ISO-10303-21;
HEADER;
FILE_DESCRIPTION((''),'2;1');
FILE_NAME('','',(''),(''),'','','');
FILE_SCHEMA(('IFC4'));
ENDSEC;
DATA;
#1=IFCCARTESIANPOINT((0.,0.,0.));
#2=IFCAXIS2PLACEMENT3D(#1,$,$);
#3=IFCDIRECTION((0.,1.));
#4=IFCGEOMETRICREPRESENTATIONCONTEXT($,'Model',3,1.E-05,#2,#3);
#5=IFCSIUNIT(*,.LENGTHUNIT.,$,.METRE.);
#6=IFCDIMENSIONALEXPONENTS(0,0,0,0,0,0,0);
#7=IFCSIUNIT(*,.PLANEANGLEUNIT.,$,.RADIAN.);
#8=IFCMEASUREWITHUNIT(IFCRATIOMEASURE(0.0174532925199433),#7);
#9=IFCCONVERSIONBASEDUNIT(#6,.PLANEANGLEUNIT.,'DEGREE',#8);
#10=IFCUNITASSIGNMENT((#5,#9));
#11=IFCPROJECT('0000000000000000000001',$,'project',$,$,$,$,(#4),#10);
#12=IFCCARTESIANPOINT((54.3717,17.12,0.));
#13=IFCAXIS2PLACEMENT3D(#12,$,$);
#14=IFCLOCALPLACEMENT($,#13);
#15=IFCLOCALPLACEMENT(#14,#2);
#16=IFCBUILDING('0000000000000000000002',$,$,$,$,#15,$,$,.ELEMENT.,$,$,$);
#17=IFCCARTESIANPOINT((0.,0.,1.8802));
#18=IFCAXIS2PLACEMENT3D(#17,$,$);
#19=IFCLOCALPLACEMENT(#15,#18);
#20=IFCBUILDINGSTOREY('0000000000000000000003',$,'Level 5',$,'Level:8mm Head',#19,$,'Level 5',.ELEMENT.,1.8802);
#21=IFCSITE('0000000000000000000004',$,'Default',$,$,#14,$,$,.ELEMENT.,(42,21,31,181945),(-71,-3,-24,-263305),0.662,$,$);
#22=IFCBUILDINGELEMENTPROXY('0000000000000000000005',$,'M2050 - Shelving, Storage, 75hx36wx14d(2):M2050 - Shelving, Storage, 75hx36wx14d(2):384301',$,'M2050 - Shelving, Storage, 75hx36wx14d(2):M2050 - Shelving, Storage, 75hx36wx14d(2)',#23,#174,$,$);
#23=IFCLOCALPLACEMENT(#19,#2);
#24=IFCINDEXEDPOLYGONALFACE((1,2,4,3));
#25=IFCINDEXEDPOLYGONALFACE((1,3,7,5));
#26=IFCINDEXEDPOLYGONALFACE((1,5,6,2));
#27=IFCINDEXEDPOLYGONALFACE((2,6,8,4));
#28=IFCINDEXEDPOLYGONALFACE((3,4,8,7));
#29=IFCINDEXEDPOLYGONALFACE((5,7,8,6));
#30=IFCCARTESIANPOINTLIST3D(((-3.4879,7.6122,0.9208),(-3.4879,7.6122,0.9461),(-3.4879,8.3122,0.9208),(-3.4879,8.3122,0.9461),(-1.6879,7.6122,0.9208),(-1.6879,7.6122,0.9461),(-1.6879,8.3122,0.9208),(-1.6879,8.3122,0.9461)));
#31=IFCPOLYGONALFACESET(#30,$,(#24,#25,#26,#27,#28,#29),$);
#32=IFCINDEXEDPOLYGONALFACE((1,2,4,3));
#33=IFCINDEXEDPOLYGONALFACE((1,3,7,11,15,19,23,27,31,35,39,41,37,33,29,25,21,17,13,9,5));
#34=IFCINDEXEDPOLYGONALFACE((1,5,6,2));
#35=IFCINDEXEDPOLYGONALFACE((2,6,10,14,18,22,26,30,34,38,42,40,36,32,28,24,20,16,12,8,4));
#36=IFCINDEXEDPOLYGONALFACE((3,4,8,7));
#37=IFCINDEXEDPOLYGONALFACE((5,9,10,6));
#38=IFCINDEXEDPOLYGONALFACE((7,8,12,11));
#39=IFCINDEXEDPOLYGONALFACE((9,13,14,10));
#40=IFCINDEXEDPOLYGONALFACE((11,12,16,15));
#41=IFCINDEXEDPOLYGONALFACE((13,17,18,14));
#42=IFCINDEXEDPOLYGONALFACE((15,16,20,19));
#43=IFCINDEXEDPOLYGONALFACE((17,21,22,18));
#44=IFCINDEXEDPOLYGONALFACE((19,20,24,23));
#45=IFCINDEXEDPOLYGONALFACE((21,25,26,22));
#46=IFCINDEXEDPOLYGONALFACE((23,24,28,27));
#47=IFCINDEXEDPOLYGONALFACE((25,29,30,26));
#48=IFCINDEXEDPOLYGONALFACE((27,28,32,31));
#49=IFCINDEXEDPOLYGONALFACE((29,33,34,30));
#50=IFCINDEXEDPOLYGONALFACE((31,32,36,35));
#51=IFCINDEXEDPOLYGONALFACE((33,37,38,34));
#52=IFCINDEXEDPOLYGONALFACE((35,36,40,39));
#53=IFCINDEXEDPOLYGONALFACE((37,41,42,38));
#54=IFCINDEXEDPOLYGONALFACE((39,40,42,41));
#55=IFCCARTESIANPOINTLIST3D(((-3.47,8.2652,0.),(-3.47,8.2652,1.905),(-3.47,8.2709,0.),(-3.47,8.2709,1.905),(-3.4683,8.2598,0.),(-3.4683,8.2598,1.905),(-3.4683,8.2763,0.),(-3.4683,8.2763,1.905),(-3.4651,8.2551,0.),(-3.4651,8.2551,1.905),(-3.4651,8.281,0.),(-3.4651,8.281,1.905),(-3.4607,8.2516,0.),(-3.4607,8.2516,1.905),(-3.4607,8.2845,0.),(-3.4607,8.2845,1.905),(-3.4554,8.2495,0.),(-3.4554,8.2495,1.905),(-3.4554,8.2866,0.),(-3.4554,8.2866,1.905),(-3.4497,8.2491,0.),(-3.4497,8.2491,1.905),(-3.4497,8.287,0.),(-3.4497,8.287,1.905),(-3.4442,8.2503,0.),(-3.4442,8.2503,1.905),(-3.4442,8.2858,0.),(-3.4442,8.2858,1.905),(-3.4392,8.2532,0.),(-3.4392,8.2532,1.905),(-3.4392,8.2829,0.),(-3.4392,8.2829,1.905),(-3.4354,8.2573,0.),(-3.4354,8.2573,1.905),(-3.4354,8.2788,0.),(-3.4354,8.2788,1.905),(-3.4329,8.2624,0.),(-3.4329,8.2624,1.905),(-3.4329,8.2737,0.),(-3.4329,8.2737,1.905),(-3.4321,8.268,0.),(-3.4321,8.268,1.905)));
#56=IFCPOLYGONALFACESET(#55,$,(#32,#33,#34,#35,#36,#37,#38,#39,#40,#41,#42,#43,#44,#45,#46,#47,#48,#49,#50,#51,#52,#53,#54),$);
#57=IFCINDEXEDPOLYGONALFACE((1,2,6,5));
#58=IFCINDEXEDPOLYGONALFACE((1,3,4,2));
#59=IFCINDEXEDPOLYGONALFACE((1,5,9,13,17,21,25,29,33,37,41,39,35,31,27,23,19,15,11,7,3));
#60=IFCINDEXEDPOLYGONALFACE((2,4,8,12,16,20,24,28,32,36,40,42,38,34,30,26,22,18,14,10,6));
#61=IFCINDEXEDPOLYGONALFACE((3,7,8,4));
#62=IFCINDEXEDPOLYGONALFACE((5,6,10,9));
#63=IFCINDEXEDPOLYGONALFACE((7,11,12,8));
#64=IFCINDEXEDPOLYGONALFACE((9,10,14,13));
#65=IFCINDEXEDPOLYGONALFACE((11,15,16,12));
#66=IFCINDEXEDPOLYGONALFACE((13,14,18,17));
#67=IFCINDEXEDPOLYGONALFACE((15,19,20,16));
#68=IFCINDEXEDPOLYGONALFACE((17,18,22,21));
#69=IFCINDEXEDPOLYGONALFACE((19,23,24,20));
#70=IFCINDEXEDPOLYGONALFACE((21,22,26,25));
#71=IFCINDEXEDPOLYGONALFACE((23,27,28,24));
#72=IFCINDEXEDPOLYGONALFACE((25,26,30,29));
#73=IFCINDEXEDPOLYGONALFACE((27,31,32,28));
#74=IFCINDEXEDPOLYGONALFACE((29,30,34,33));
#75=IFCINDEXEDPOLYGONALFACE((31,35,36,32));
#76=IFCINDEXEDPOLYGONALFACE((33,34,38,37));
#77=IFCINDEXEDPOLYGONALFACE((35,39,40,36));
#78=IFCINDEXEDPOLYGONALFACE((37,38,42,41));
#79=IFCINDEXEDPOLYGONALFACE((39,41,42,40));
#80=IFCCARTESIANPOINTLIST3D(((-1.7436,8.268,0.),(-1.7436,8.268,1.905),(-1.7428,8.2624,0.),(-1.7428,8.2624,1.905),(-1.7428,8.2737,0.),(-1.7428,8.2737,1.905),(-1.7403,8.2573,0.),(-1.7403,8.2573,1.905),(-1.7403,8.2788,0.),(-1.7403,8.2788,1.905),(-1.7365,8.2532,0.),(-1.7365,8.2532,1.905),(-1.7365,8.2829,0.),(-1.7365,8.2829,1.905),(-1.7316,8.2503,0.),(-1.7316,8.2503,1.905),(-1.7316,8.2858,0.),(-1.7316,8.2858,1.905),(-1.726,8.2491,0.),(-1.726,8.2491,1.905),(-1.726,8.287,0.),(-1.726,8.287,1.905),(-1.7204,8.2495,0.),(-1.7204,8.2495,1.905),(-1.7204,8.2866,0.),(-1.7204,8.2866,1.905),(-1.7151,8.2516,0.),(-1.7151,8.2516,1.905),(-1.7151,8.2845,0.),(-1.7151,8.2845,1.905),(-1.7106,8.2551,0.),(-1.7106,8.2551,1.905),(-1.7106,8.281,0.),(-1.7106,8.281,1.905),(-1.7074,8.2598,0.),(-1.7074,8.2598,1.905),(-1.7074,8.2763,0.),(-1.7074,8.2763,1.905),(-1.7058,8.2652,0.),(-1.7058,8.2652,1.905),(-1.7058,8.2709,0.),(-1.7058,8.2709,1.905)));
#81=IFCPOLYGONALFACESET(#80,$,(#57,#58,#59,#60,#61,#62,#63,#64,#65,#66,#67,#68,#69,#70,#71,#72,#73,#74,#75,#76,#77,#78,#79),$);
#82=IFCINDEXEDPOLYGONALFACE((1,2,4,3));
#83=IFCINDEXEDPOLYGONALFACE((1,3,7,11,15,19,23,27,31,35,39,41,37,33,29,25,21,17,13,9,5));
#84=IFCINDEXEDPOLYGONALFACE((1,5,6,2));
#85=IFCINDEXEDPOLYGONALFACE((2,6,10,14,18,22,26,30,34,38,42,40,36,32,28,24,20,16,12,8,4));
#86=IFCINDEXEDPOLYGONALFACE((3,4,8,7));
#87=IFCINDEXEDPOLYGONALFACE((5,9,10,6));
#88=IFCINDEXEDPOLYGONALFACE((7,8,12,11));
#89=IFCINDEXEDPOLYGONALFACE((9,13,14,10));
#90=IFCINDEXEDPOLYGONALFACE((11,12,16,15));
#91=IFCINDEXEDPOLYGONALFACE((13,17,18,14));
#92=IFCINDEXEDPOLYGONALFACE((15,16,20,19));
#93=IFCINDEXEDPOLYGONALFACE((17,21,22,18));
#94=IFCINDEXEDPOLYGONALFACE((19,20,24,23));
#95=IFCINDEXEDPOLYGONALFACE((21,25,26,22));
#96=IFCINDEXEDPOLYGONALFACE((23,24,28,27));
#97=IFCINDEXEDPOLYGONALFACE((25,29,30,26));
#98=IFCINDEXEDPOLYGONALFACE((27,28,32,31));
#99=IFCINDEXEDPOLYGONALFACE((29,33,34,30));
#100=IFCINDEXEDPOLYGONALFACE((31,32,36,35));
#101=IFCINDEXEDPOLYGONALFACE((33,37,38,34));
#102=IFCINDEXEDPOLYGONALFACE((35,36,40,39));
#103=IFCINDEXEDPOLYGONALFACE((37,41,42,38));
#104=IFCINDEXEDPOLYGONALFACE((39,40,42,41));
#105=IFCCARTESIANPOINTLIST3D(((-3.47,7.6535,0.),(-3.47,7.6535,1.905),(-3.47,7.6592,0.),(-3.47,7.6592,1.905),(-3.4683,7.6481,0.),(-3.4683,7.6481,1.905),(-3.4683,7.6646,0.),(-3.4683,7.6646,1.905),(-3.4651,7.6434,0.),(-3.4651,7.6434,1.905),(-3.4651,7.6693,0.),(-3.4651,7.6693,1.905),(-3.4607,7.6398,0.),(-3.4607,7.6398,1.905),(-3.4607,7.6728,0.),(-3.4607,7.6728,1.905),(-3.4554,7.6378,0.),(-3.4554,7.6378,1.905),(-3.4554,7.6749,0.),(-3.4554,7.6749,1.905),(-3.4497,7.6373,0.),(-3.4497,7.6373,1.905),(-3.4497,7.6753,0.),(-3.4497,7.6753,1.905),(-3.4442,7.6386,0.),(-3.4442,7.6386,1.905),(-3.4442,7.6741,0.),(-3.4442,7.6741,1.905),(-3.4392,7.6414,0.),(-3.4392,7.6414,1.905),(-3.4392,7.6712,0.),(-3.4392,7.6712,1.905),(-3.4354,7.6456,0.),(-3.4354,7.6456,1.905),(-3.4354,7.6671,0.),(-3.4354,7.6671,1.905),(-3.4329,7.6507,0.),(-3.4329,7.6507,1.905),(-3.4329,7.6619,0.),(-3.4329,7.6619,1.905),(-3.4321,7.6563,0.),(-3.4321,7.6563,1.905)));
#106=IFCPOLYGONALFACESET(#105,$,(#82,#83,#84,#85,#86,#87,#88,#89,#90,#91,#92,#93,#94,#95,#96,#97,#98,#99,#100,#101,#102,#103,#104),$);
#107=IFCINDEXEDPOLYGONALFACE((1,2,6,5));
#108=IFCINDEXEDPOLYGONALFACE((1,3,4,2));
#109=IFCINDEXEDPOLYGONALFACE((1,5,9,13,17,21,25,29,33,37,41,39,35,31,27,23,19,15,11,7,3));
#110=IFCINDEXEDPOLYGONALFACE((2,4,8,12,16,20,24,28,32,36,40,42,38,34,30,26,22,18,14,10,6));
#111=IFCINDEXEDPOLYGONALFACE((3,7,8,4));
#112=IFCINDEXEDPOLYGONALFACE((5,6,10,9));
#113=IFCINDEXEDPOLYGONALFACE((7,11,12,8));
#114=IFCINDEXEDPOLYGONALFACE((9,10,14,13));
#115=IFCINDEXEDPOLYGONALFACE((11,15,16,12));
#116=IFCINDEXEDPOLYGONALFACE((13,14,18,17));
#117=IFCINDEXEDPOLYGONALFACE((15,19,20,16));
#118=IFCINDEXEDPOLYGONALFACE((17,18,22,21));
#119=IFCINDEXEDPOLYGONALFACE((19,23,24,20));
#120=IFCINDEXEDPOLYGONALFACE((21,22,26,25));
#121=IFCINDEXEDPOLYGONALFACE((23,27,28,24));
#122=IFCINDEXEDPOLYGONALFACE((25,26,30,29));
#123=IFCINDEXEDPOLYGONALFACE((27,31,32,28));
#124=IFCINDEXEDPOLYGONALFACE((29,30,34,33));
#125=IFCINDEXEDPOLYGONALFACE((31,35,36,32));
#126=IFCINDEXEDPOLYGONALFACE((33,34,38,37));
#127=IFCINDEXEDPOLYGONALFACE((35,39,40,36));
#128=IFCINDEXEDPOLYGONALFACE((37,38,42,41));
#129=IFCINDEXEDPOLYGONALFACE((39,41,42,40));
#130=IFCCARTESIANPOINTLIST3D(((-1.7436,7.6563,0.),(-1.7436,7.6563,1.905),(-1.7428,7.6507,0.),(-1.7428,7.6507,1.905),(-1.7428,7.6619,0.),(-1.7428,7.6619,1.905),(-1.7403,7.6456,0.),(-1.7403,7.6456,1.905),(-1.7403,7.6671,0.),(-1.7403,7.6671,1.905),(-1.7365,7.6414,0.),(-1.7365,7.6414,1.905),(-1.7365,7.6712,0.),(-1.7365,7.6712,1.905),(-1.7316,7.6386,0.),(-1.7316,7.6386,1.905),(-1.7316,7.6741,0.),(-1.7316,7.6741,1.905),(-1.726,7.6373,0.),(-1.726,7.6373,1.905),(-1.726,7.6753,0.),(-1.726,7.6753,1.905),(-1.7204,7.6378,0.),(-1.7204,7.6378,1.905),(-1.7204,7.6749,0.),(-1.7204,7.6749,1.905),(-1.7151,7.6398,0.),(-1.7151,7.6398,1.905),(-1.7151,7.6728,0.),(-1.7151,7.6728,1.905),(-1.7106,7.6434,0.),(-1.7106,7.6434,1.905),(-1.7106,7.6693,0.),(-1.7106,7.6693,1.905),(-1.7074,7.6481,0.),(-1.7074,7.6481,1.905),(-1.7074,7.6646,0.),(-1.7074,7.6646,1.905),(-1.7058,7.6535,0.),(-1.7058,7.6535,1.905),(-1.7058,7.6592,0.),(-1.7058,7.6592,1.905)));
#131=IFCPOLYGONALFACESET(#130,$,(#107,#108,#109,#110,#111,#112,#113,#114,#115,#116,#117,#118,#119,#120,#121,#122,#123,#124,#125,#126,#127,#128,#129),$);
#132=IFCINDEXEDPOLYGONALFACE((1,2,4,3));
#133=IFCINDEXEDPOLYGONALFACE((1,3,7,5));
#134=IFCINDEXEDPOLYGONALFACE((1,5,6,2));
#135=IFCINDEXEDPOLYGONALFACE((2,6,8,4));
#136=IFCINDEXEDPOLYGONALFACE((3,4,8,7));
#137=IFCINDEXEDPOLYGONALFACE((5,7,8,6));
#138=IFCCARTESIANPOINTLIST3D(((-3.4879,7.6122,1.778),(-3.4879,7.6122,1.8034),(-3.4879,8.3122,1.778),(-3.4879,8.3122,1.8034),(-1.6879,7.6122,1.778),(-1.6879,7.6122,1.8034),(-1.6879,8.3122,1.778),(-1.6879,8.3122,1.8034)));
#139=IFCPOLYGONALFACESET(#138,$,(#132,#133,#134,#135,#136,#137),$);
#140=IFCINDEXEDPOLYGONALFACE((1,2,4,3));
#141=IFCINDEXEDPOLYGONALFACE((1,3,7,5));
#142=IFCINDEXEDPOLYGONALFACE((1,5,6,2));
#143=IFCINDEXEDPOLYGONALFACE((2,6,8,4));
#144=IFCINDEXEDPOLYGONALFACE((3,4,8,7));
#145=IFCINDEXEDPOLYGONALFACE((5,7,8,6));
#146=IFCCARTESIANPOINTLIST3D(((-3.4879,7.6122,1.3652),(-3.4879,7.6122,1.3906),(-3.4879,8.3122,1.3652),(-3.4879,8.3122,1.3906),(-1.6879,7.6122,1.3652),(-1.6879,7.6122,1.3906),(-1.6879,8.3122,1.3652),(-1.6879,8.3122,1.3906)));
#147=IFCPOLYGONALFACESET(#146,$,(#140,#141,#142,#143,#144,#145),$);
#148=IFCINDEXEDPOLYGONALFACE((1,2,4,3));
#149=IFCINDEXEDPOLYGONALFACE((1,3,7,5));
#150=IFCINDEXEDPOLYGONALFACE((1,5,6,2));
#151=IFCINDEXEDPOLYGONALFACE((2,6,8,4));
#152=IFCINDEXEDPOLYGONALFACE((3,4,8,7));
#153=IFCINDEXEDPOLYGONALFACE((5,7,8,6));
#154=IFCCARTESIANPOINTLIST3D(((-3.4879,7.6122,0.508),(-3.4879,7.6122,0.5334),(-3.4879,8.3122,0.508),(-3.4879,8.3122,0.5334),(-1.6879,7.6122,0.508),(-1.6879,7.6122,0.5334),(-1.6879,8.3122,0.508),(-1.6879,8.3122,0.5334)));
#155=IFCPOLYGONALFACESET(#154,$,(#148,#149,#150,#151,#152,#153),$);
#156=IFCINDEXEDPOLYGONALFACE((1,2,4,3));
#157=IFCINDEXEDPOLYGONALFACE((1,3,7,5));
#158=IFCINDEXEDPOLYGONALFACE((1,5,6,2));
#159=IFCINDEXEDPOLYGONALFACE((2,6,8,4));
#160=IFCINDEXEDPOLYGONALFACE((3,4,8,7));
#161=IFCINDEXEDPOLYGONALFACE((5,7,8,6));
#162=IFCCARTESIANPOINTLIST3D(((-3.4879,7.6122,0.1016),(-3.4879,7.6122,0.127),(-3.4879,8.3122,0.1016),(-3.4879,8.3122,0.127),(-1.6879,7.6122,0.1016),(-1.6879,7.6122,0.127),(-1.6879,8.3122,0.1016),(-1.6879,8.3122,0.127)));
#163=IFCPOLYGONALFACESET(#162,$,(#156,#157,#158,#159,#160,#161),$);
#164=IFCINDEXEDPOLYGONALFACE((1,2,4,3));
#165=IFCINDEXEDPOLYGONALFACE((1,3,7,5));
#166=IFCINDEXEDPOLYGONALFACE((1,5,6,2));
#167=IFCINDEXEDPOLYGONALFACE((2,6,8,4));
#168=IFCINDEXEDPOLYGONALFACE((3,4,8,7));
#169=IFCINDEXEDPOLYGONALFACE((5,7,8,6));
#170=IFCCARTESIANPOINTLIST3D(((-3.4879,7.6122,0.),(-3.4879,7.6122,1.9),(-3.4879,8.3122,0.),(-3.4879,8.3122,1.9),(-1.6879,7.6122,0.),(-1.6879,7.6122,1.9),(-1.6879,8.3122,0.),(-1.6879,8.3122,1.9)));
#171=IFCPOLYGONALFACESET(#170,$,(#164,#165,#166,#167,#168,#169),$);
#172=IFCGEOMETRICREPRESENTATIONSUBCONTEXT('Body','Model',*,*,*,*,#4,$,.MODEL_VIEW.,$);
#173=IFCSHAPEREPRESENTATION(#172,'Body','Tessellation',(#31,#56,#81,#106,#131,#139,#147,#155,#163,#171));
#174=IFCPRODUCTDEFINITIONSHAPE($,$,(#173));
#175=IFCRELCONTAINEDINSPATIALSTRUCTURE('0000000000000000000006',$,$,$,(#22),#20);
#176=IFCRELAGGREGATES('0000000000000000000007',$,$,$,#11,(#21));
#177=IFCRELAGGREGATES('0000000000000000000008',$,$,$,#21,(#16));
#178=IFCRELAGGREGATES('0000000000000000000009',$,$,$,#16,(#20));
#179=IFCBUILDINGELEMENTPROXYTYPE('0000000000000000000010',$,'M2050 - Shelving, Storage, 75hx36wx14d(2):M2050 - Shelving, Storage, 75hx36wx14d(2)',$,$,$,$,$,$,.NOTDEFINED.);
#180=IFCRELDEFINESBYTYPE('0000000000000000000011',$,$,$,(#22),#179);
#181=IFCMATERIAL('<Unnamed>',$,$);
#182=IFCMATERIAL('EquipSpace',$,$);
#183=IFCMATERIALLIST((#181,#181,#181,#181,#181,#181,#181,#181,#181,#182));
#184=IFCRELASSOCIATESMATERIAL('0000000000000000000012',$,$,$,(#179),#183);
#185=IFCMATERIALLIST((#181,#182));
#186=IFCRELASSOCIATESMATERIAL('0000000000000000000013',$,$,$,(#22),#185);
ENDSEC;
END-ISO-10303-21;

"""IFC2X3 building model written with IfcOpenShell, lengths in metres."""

from ifc_helpers import new_model, entity, si_unit, converted_unit, direction, frame, frame_2d, origin, origin_2d_with_axis, place, context, subcontext, project, spatial, rectangle, circle, extrude, source, transform, mapped, material, material_list, type_object, type_shapes, element, save


model = new_model("IFC2X3")

# Units and contexts
model_context = context("Model", 3, precision=1e-05, world=origin(), true_north=direction((0.0, 1.0)))
body_context = subcontext(model_context, "Body", "Model", "MODEL_VIEW")
ifc_project = project(units=[si_unit("LENGTHUNIT", "METRE"), converted_unit("PLANEANGLEUNIT", "DEGREE", entity("IfcRatioMeasure", 0.0174532925199433), si_unit("PLANEANGLEUNIT", "RADIAN"), dimensions=[0, 0, 0, 0, 0, 0, 0])], contexts=[model_context])

# Site, building, storey
site_placement = place(None, frame((54.3717, 17.12, 0.0)))
site = spatial("IfcSite", under=ifc_project, at=site_placement, Name="Default", CompositionType="ELEMENT", RefLatitude=(42, 21, 31, 181945), RefLongitude=(-71, -3, -24, -263305), RefElevation=0.662)
building_placement = place(site_placement, origin())
building = spatial("IfcBuilding", under=site, at=building_placement, CompositionType="ELEMENT")
storey_placement = place(building_placement, frame((0.0, 0.0, 1.8802)))
storey = spatial("IfcBuildingStorey", under=building, at=storey_placement, Name="Level 5", ObjectType="Level:8mm Head", LongName="Level 5", CompositionType="ELEMENT", Elevation=1.8802)

# Building element proxy
ifc_material_1 = material(Name="<Unnamed>")
ifc_material_2 = material(Name="EquipSpace")
ifc_material_list_1 = material_list([ifc_material_1, ifc_material_1, ifc_material_1, ifc_material_1, ifc_material_1, ifc_material_1, ifc_material_1, ifc_material_1, ifc_material_1, ifc_material_2])
building_element_proxy_type = type_object("IfcBuildingElementProxyType", Name="M2050 - Shelving, Storage, 75hx36wx14d(2):M2050 - Shelving, Storage, 75hx36wx14d(2)", PredefinedType="NOTDEFINED", material=ifc_material_list_1)
shared_shape = source(origin(), body_context, "Body", "SweptSolid", [
    extrude(rectangle(XDim=1.8, YDim=0.7, at=origin_2d_with_axis()), frame((0.0, 0.0, 0.9207), z_axis=(0.0, 0.0, 1.0), x_axis=(-1.0, 0.0, 0.0)), (0.0, 0.0, 1.0), 0.0254),
    extrude(circle(Radius=0.0191, at=origin_2d_with_axis()), frame((0.8633, -0.3059, 0.0), z_axis=(0.0, 0.0, 1.0), x_axis=(-1.0, 0.0, 0.0)), (0.0, 0.0, 1.0), 1.905),
    extrude(circle(Radius=0.0191, at=origin_2d_with_axis()), frame((-0.8633, -0.3059, 0.0)), (0.0, 0.0, 1.0), 1.905),
    extrude(circle(Radius=0.0191, at=origin_2d_with_axis()), frame((0.8633, 0.3059, 0.0), z_axis=(0.0, 0.0, 1.0), x_axis=(-1.0, 0.0, 0.0)), (0.0, 0.0, 1.0), 1.905),
    extrude(circle(Radius=0.0191, at=origin_2d_with_axis()), frame((-0.8633, 0.3059, 0.0)), (0.0, 0.0, 1.0), 1.905),
    extrude(rectangle(XDim=1.8, YDim=0.7, at=origin_2d_with_axis()), frame((0.0, 0.0, 1.778), z_axis=(0.0, 0.0, 1.0), x_axis=(-1.0, 0.0, 0.0)), (0.0, 0.0, 1.0), 0.0254),
    extrude(rectangle(XDim=1.8, YDim=0.7, at=origin_2d_with_axis()), frame((0.0, 0.0, 1.3653), z_axis=(0.0, 0.0, 1.0), x_axis=(-1.0, 0.0, 0.0)), (0.0, 0.0, 1.0), 0.0254),
    extrude(rectangle(XDim=1.8, YDim=0.7, at=origin_2d_with_axis()), frame((0.0, 0.0, 0.508), z_axis=(0.0, 0.0, 1.0), x_axis=(-1.0, 0.0, 0.0)), (0.0, 0.0, 1.0), 0.0254),
    extrude(rectangle(XDim=1.8, YDim=0.7, at=origin_2d_with_axis()), frame((0.0, 0.0, 0.1016), z_axis=(0.0, 0.0, 1.0), x_axis=(-1.0, 0.0, 0.0)), (0.0, 0.0, 1.0), 0.0254),
    extrude(rectangle(XDim=0.7, YDim=1.8, at=frame_2d((0.0, 0.18), x_axis=(1.0, 0.0))), frame((-0.18, 0.0, 0.0), z_axis=(0.0, 0.0, 1.0), x_axis=(0.0, -1.0, 0.0)), (0.0, 0.0, 1.0), 1.9),
])
type_shapes(building_element_proxy_type, [shared_shape])
ifc_material_list_2 = material_list([ifc_material_1, ifc_material_2])
proxy_1_placement = place(storey_placement, frame((-2.5879, 7.9622, 0.0), z_axis=(0.0, 0.0, 1.0), x_axis=(-1.0, 0.0, 0.0)))
element("IfcBuildingElementProxy", 1, at=proxy_1_placement, inside=storey, type_object=building_element_proxy_type, material=ifc_material_list_2, Name="M2050 - Shelving, Storage, 75hx36wx14d(2):M2050 - Shelving, Storage, 75hx36wx14d(2):384301", ObjectType="M2050 - Shelving, Storage, 75hx36wx14d(2):M2050 - Shelving, Storage, 75hx36wx14d(2)", context=body_context, shape_type="MappedRepresentation", body=[
    mapped(shared_shape, transform((0.0, 0.0, 0.0), scale=1.0)),
])

save(model, "model.ifc")
